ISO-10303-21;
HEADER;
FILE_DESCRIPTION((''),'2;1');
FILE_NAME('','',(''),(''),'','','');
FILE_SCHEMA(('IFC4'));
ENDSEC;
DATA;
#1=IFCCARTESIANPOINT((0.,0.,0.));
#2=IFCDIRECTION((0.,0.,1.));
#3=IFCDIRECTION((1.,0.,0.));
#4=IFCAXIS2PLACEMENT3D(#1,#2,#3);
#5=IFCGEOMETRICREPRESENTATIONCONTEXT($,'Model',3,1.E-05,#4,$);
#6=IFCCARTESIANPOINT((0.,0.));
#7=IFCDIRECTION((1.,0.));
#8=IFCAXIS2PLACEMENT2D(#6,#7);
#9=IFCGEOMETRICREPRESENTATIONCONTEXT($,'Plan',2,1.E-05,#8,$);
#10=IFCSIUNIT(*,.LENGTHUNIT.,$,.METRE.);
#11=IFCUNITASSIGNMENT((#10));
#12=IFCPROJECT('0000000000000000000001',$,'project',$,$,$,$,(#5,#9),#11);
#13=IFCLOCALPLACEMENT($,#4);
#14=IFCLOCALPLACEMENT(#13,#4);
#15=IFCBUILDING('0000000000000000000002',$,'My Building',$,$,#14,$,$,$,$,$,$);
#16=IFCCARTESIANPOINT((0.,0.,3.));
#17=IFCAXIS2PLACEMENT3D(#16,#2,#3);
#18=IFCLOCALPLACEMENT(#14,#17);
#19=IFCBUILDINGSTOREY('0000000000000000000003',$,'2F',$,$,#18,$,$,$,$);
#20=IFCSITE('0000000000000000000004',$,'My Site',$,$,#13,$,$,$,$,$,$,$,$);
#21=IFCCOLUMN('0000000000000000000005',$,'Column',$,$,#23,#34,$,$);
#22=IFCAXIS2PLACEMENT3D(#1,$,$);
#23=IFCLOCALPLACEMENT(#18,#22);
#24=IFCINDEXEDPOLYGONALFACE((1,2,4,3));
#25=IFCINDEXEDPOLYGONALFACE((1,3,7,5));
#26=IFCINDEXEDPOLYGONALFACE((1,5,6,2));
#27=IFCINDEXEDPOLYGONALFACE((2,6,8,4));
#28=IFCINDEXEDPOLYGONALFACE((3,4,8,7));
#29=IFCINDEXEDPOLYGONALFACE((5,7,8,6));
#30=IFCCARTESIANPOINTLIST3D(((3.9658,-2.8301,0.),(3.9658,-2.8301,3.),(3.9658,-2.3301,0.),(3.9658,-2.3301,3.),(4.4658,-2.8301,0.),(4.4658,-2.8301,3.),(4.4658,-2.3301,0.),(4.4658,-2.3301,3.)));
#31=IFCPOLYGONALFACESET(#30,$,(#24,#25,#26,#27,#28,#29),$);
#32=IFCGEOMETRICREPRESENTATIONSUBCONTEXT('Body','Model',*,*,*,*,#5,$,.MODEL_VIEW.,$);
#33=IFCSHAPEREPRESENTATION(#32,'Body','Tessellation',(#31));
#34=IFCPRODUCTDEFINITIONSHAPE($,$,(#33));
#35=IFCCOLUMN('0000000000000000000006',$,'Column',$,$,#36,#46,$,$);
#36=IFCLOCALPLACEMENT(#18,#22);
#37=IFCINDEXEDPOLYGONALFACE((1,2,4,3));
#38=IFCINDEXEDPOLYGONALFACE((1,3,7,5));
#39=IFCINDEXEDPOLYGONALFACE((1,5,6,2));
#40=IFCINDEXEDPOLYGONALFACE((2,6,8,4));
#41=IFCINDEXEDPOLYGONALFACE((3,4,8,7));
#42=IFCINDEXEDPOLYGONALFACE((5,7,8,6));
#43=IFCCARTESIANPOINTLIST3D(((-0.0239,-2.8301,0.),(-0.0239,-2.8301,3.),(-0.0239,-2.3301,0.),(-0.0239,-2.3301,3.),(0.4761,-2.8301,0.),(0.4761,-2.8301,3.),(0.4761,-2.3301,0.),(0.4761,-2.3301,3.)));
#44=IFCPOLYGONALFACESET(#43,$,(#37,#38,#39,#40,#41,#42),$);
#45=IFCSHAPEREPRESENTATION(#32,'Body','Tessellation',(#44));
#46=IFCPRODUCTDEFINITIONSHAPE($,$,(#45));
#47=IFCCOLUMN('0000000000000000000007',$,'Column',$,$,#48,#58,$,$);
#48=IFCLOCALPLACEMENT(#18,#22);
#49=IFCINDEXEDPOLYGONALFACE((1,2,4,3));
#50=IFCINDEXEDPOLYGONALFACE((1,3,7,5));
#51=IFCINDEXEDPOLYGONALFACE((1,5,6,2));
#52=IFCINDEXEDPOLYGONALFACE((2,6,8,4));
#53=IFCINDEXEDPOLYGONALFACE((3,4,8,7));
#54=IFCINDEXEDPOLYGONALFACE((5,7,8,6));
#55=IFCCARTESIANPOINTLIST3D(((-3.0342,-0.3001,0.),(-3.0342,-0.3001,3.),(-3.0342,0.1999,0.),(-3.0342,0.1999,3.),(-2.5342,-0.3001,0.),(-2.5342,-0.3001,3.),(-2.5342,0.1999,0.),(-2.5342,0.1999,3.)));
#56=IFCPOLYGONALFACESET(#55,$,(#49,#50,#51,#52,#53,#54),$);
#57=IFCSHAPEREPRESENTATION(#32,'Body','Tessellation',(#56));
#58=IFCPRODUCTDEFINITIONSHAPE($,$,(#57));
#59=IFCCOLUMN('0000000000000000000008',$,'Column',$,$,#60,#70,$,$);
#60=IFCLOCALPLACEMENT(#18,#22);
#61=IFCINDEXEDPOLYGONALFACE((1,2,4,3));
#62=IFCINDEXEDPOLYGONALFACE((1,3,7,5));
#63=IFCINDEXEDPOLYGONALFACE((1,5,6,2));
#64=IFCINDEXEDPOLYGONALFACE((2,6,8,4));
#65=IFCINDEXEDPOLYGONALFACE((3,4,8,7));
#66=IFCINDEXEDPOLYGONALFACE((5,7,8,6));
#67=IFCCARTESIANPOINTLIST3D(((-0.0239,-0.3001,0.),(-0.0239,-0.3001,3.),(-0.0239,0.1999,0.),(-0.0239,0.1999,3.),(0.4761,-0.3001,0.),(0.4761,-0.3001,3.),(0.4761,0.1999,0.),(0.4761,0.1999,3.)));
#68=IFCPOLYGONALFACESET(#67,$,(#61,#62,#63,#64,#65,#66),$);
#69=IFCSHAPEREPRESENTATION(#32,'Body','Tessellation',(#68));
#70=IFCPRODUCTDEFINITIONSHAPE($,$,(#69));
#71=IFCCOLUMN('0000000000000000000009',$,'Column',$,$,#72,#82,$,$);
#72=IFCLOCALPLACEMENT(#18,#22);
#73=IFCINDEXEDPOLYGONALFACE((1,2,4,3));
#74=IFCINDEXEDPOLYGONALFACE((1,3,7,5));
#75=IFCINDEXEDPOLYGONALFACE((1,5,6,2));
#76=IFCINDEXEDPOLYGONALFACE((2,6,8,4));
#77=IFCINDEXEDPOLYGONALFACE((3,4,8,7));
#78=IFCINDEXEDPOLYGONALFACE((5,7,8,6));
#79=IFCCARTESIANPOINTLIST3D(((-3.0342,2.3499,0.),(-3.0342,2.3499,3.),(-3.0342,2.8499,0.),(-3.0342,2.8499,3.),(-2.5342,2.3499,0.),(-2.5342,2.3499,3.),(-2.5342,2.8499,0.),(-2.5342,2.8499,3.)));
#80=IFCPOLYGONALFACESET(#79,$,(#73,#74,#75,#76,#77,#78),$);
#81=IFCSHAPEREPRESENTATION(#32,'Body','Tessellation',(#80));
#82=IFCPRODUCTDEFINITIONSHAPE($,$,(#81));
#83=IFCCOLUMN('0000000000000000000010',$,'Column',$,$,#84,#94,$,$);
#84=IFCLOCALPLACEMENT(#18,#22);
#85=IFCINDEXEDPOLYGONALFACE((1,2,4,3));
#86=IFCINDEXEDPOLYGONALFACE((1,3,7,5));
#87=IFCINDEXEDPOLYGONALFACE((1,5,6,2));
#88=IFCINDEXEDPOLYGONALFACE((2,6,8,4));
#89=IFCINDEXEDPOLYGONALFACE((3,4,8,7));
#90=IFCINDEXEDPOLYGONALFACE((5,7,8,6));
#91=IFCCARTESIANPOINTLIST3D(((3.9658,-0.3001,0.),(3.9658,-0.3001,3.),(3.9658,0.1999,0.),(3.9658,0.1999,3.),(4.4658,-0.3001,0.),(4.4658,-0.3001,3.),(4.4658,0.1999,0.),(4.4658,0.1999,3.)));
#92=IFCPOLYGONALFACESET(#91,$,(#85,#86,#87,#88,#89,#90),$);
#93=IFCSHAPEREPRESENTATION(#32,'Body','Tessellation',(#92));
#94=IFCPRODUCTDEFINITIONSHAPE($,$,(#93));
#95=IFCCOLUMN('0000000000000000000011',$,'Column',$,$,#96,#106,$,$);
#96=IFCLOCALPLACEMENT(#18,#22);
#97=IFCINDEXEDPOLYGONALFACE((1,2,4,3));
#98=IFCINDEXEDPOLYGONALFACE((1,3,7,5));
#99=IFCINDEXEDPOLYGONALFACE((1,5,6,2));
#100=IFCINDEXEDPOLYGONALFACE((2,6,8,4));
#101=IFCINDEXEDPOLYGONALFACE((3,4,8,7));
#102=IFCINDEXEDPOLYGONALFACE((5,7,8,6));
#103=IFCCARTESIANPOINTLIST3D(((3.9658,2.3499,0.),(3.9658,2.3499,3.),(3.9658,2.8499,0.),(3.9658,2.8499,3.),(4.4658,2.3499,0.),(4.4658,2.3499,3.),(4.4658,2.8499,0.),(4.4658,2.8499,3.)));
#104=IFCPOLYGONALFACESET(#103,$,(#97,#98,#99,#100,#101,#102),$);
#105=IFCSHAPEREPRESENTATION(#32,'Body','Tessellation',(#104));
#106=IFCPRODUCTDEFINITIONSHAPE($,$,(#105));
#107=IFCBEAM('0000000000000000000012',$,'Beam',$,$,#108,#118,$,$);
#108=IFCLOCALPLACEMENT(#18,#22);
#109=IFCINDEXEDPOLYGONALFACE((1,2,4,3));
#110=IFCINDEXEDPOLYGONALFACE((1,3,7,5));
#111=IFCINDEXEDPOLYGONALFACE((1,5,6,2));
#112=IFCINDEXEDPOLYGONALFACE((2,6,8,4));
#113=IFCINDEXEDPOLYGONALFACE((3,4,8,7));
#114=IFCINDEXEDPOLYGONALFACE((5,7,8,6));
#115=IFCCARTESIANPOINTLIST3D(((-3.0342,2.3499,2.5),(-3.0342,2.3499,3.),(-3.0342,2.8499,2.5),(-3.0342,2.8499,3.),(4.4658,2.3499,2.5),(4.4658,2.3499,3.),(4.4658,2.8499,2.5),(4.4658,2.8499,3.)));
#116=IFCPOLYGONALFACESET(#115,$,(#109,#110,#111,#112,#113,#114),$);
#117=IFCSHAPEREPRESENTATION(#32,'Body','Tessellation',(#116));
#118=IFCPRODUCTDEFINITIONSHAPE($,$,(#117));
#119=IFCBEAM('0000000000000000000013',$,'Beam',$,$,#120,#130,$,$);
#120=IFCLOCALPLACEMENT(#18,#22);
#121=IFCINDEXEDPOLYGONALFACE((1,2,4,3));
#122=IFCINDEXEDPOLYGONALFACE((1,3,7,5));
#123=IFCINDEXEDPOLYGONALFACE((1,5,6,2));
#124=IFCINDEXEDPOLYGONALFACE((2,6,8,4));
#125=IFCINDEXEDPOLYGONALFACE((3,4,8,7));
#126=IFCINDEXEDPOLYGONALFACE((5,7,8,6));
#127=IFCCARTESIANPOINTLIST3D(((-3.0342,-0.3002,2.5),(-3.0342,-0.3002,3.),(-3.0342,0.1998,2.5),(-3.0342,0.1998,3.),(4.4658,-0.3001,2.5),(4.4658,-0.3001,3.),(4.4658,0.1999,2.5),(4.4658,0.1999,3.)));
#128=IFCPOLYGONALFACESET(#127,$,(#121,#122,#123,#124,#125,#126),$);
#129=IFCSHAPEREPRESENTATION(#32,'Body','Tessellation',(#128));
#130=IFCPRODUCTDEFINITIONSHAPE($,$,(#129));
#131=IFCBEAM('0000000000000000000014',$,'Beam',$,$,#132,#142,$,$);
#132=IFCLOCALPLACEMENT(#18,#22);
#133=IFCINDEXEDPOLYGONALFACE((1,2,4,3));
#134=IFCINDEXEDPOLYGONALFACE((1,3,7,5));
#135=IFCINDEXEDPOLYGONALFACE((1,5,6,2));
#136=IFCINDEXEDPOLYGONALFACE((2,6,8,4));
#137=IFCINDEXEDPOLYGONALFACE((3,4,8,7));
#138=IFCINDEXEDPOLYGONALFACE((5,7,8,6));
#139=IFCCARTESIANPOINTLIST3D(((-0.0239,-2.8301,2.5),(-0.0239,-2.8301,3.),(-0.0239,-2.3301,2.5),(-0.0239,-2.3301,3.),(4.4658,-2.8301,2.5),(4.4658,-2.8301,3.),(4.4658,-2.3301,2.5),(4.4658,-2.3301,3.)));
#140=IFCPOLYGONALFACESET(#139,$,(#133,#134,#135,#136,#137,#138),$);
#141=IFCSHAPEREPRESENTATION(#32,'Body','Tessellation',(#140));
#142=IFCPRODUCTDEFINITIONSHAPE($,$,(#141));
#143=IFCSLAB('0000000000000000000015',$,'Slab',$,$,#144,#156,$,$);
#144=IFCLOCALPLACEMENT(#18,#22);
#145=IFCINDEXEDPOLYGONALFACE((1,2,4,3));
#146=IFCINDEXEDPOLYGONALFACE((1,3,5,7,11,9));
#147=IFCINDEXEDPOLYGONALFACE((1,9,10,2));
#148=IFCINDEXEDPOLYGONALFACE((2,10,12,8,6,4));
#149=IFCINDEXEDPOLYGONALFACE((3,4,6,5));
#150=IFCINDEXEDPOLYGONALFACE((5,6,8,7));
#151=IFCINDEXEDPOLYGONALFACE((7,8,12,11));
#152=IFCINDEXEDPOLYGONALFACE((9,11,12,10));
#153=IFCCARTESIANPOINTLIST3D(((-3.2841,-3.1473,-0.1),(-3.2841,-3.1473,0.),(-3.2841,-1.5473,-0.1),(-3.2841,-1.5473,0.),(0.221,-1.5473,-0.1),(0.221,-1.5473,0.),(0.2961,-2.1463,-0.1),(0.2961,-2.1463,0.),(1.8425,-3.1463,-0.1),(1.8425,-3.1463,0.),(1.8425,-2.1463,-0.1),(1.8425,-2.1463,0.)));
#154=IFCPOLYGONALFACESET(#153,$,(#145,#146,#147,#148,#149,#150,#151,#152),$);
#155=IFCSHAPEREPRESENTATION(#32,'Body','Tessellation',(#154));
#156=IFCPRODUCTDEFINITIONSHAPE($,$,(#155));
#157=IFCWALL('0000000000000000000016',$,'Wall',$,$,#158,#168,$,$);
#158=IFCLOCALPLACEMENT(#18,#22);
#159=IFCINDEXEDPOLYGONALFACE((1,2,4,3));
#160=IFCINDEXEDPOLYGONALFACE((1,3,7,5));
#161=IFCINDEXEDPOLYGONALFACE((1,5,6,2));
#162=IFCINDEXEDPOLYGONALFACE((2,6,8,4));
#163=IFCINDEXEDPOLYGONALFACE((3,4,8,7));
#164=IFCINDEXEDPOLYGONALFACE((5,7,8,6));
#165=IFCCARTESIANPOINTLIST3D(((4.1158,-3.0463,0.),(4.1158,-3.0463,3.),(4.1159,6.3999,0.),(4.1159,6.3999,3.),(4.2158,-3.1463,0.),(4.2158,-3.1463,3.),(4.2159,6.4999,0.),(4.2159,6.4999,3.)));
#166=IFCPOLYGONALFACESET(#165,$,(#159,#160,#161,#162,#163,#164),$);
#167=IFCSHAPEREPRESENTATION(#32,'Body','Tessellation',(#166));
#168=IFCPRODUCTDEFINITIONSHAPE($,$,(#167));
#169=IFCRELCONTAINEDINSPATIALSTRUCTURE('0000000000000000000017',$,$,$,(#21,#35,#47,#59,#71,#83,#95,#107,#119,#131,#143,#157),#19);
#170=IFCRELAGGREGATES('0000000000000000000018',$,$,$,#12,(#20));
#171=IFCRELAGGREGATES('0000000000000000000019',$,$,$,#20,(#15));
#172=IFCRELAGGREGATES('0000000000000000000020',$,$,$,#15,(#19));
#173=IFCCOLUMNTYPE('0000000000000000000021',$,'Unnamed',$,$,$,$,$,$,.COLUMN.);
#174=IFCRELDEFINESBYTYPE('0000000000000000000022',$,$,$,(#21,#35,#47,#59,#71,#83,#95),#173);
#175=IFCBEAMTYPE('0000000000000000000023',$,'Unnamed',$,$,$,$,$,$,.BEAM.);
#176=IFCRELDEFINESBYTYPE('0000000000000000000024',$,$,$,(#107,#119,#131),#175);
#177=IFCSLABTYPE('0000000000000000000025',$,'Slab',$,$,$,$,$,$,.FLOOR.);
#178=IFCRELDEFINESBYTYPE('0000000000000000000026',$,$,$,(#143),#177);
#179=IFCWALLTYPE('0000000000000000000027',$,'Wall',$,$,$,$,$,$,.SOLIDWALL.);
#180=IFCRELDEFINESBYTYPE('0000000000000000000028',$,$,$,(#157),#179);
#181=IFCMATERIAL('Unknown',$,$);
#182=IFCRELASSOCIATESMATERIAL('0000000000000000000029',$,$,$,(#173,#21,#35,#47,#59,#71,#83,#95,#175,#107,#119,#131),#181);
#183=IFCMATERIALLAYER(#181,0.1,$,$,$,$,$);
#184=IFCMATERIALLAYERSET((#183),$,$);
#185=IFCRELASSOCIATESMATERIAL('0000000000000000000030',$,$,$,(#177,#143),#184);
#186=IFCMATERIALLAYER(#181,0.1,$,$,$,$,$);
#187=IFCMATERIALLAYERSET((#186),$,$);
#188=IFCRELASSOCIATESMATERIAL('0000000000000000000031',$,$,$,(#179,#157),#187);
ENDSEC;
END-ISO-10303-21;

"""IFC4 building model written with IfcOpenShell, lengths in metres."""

from ifc_helpers import new_model, si_unit, frame, origin_with_axes, origin_2d_with_axis, place, context, subcontext, project, spatial, line, indexed_curve, rectangle, outline, extrude, material, layer, layer_set, layer_usage, material_profile, profile_set, profile_usage, type_object, element, save


model = new_model("IFC4")

# Units and contexts
model_context = context("Model", 3, precision=1e-05, world=origin_with_axes())
plan_context = context("Plan", 2, precision=1e-05, world=origin_2d_with_axis())
body_context_1 = subcontext(model_context, "Body", "Model", "MODEL_VIEW")
ifc_project = project(units=[si_unit("LENGTHUNIT", "METRE")], contexts=[model_context, plan_context])

# Site, building, storey
site_placement = place(None, origin_with_axes())
site = spatial("IfcSite", under=ifc_project, at=site_placement, Name="My Site")
building_placement = place(site_placement, origin_with_axes())
building = spatial("IfcBuilding", under=site, at=building_placement, Name="My Building")
storey_placement = place(building_placement, frame((0.0, 0.0, 3.0), z_axis=(0.0, 0.0, 1.0), x_axis=(1.0, 0.0, 0.0)))
storey = spatial("IfcBuildingStorey", under=building, at=storey_placement, Name="2F")

# Columns
ifc_material_1 = material(Name="Unknown")
ifc_material_profile_1 = material_profile(ifc_material_1, rectangle(XDim=0.5, YDim=0.5))
ifc_profile_set_1 = profile_set([ifc_material_profile_1])
ifc_profile_usage_1 = profile_usage(ifc_profile_set_1, cardinal=1)
column_type = type_object("IfcColumnType", Name="Unnamed", PredefinedType="COLUMN", material=ifc_profile_set_1)
column_1_placement = place(storey_placement, frame((4.4658, -2.8301, 0.0), z_axis=(0.0, 0.0, 1.0), x_axis=(1.0, 0.0, 0.0)))
element("IfcColumn", 1, at=column_1_placement, inside=storey, type_object=column_type, material=ifc_profile_usage_1, Name="Column", context=body_context_1, shape_type="SweptSolid", body=[
    extrude(rectangle(XDim=0.5, YDim=0.5), frame((-0.25, 0.25, 0.0), z_axis=(0.0, 0.0, 1.0), x_axis=(1.0, 0.0, 0.0)), (0.0, 0.0, 1.0), 3.0),
])
ifc_profile_usage_2 = profile_usage(ifc_profile_set_1, cardinal=1)
column_2_placement = place(storey_placement, frame((0.4761, -2.8301, 0.0), z_axis=(0.0, 0.0, 1.0), x_axis=(1.0, 0.0, 0.0)))
element("IfcColumn", 2, at=column_2_placement, inside=storey, type_object=column_type, material=ifc_profile_usage_2, Name="Column", context=body_context_1, shape_type="SweptSolid", body=[
    extrude(rectangle(XDim=0.5, YDim=0.5), frame((-0.25, 0.25, 0.0), z_axis=(0.0, 0.0, 1.0), x_axis=(1.0, 0.0, 0.0)), (0.0, 0.0, 1.0), 3.0),
])
ifc_profile_usage_3 = profile_usage(ifc_profile_set_1, cardinal=1)
column_3_placement = place(storey_placement, frame((-2.5342, -0.3001, 0.0), z_axis=(0.0, 0.0, 1.0), x_axis=(1.0, 0.0, 0.0)))
element("IfcColumn", 3, at=column_3_placement, inside=storey, type_object=column_type, material=ifc_profile_usage_3, Name="Column", context=body_context_1, shape_type="SweptSolid", body=[
    extrude(rectangle(XDim=0.5, YDim=0.5), frame((-0.25, 0.25, 0.0), z_axis=(0.0, 0.0, 1.0), x_axis=(1.0, 0.0, 0.0)), (0.0, 0.0, 1.0), 3.0),
])
ifc_profile_usage_4 = profile_usage(ifc_profile_set_1, cardinal=1)
column_4_placement = place(storey_placement, frame((0.4761, -0.3001, 0.0), z_axis=(0.0, 0.0, 1.0), x_axis=(1.0, 0.0, 0.0)))
element("IfcColumn", 4, at=column_4_placement, inside=storey, type_object=column_type, material=ifc_profile_usage_4, Name="Column", context=body_context_1, shape_type="SweptSolid", body=[
    extrude(rectangle(XDim=0.5, YDim=0.5), frame((-0.25, 0.25, 0.0), z_axis=(0.0, 0.0, 1.0), x_axis=(1.0, 0.0, 0.0)), (0.0, 0.0, 1.0), 3.0),
])
ifc_profile_usage_5 = profile_usage(ifc_profile_set_1, cardinal=1)
column_5_placement = place(storey_placement, frame((-2.5342, 2.3499, 0.0), z_axis=(0.0, 0.0, 1.0), x_axis=(1.0, 0.0, 0.0)))
element("IfcColumn", 5, at=column_5_placement, inside=storey, type_object=column_type, material=ifc_profile_usage_5, Name="Column", context=body_context_1, shape_type="SweptSolid", body=[
    extrude(rectangle(XDim=0.5, YDim=0.5), frame((-0.25, 0.25, 0.0), z_axis=(0.0, 0.0, 1.0), x_axis=(1.0, 0.0, 0.0)), (0.0, 0.0, 1.0), 3.0),
])
ifc_profile_usage_6 = profile_usage(ifc_profile_set_1, cardinal=1)
column_6_placement = place(storey_placement, frame((4.4658, -0.3001, 0.0), z_axis=(0.0, 0.0, 1.0), x_axis=(1.0, 0.0, 0.0)))
element("IfcColumn", 6, at=column_6_placement, inside=storey, type_object=column_type, material=ifc_profile_usage_6, Name="Column", context=body_context_1, shape_type="SweptSolid", body=[
    extrude(rectangle(XDim=0.5, YDim=0.5), frame((-0.25, 0.25, 0.0), z_axis=(0.0, 0.0, 1.0), x_axis=(1.0, 0.0, 0.0)), (0.0, 0.0, 1.0), 3.0),
])
ifc_profile_usage_7 = profile_usage(ifc_profile_set_1, cardinal=1)
column_7_placement = place(storey_placement, frame((4.4658, 2.3499, 0.0), z_axis=(0.0, 0.0, 1.0), x_axis=(1.0, 0.0, 0.0)))
element("IfcColumn", 7, at=column_7_placement, inside=storey, type_object=column_type, material=ifc_profile_usage_7, Name="Column", context=body_context_1, shape_type="SweptSolid", body=[
    extrude(rectangle(XDim=0.5, YDim=0.5), frame((-0.25, 0.25, 0.0), z_axis=(0.0, 0.0, 1.0), x_axis=(1.0, 0.0, 0.0)), (0.0, 0.0, 1.0), 3.0),
])

# Beams
ifc_material_profile_2 = material_profile(ifc_material_1, rectangle(XDim=0.5, YDim=0.5))
ifc_profile_set_2 = profile_set([ifc_material_profile_2])
ifc_profile_usage_8 = profile_usage(ifc_profile_set_2, cardinal=1)
beam_type = type_object("IfcBeamType", Name="Unnamed", PredefinedType="BEAM", material=ifc_profile_set_2)
beam_1_placement = place(storey_placement, frame((4.4658, 2.3499, 2.5), z_axis=(-1.0, 0.0, 0.0), x_axis=(0.0, -1.0, 0.0)))
element("IfcBeam", 8, at=beam_1_placement, inside=storey, type_object=beam_type, material=ifc_profile_usage_8, Name="Beam", context=body_context_1, shape_type="SweptSolid", body=[
    extrude(rectangle(XDim=0.5, YDim=0.5), frame((-0.25, 0.25, 0.0), z_axis=(0.0, 0.0, 1.0), x_axis=(1.0, 0.0, 0.0)), (0.0, 0.0, 1.0), 7.5),
])
ifc_profile_usage_9 = profile_usage(ifc_profile_set_2, cardinal=1)
beam_2_placement = place(storey_placement, frame((4.4658, -0.3001, 2.5), z_axis=(-1.0, -0.000004, 0.000001), x_axis=(0.000004, -1.0, 0.0)))
element("IfcBeam", 9, at=beam_2_placement, inside=storey, type_object=beam_type, material=ifc_profile_usage_9, Name="Beam", context=body_context_1, shape_type="SweptSolid", body=[
    extrude(rectangle(XDim=0.5, YDim=0.5), frame((-0.25, 0.25, 0.0), z_axis=(0.0, 0.0, 1.0), x_axis=(1.0, 0.0, 0.0)), (0.0, 0.0, 1.0), 7.5),
])
ifc_profile_usage_10 = profile_usage(ifc_profile_set_2, cardinal=1)
beam_3_placement = place(storey_placement, frame((4.4658, -2.8301, 2.5), z_axis=(-1.0, 0.0, 0.0), x_axis=(0.0, -1.0, 0.0)))
element("IfcBeam", 10, at=beam_3_placement, inside=storey, type_object=beam_type, material=ifc_profile_usage_10, Name="Beam", context=body_context_1, shape_type="SweptSolid", body=[
    extrude(rectangle(XDim=0.5, YDim=0.5), frame((-0.25, 0.25, 0.0), z_axis=(0.0, 0.0, 1.0), x_axis=(1.0, 0.0, 0.0)), (0.0, 0.0, 1.0), 4.4897),
])

# Slab
ifc_layer_1 = layer(ifc_material_1, 0.1)
ifc_layer_set_1 = layer_set([ifc_layer_1])
ifc_layer_usage_1 = layer_usage(ifc_layer_set_1, "AXIS3", "POSITIVE", -0.1)
slab_type = type_object("IfcSlabType", Name="Slab", PredefinedType="FLOOR", material=ifc_layer_set_1)
slab_placement = place(storey_placement, frame((-3.2841, -1.5473, 0.0), z_axis=(0.0, 0.0, 1.0), x_axis=(1.0, 0.0, 0.0)))
element("IfcSlab", 11, at=slab_placement, inside=storey, type_object=slab_type, material=ifc_layer_usage_1, Name="Slab", context=body_context_1, shape_type="SweptSolid", body=[
    extrude(outline(indexed_curve([(0.0, 0.0), (0.0, -1.6), (5.1266, -1.599), (5.1266, -0.599), (3.5803, -0.599), (3.5052, 0.0), (0.0, 0.0)])), frame((0.0, 0.0, -0.1), z_axis=(0.0, 0.0, 1.0), x_axis=(1.0, 0.0, 0.0)), (0.0, 0.0, 1.0), 0.1),
])

# Wall
ifc_layer_2 = layer(ifc_material_1, 0.1)
ifc_layer_set_2 = layer_set([ifc_layer_2])
ifc_layer_usage_2 = layer_usage(ifc_layer_set_2, "AXIS2", "POSITIVE", 0.0)
wall_type = type_object("IfcWallType", Name="Wall", PredefinedType="SOLIDWALL", material=ifc_layer_set_2)
wall_1_placement = place(storey_placement, frame((4.2158, -3.1463, 0.0), z_axis=(0.0, 0.0, 1.0), x_axis=(0.0, 1.0, 0.0)))
element("IfcWall", 12, at=wall_1_placement, inside=storey, type_object=wall_type, material=ifc_layer_usage_2, Name="Wall", context=body_context_1, shape_type="SweptSolid", body=[
    extrude(outline(indexed_curve([(0.0, 0.0), (0.1, 0.1), (9.5461, 0.1), (9.6461, 0.0)], segments=[line(1, 2, 3, 4, 1)])), origin_with_axes(), (0.0, 0.0, 1.0), 3.0),
])

save(model, "model.ifc")
